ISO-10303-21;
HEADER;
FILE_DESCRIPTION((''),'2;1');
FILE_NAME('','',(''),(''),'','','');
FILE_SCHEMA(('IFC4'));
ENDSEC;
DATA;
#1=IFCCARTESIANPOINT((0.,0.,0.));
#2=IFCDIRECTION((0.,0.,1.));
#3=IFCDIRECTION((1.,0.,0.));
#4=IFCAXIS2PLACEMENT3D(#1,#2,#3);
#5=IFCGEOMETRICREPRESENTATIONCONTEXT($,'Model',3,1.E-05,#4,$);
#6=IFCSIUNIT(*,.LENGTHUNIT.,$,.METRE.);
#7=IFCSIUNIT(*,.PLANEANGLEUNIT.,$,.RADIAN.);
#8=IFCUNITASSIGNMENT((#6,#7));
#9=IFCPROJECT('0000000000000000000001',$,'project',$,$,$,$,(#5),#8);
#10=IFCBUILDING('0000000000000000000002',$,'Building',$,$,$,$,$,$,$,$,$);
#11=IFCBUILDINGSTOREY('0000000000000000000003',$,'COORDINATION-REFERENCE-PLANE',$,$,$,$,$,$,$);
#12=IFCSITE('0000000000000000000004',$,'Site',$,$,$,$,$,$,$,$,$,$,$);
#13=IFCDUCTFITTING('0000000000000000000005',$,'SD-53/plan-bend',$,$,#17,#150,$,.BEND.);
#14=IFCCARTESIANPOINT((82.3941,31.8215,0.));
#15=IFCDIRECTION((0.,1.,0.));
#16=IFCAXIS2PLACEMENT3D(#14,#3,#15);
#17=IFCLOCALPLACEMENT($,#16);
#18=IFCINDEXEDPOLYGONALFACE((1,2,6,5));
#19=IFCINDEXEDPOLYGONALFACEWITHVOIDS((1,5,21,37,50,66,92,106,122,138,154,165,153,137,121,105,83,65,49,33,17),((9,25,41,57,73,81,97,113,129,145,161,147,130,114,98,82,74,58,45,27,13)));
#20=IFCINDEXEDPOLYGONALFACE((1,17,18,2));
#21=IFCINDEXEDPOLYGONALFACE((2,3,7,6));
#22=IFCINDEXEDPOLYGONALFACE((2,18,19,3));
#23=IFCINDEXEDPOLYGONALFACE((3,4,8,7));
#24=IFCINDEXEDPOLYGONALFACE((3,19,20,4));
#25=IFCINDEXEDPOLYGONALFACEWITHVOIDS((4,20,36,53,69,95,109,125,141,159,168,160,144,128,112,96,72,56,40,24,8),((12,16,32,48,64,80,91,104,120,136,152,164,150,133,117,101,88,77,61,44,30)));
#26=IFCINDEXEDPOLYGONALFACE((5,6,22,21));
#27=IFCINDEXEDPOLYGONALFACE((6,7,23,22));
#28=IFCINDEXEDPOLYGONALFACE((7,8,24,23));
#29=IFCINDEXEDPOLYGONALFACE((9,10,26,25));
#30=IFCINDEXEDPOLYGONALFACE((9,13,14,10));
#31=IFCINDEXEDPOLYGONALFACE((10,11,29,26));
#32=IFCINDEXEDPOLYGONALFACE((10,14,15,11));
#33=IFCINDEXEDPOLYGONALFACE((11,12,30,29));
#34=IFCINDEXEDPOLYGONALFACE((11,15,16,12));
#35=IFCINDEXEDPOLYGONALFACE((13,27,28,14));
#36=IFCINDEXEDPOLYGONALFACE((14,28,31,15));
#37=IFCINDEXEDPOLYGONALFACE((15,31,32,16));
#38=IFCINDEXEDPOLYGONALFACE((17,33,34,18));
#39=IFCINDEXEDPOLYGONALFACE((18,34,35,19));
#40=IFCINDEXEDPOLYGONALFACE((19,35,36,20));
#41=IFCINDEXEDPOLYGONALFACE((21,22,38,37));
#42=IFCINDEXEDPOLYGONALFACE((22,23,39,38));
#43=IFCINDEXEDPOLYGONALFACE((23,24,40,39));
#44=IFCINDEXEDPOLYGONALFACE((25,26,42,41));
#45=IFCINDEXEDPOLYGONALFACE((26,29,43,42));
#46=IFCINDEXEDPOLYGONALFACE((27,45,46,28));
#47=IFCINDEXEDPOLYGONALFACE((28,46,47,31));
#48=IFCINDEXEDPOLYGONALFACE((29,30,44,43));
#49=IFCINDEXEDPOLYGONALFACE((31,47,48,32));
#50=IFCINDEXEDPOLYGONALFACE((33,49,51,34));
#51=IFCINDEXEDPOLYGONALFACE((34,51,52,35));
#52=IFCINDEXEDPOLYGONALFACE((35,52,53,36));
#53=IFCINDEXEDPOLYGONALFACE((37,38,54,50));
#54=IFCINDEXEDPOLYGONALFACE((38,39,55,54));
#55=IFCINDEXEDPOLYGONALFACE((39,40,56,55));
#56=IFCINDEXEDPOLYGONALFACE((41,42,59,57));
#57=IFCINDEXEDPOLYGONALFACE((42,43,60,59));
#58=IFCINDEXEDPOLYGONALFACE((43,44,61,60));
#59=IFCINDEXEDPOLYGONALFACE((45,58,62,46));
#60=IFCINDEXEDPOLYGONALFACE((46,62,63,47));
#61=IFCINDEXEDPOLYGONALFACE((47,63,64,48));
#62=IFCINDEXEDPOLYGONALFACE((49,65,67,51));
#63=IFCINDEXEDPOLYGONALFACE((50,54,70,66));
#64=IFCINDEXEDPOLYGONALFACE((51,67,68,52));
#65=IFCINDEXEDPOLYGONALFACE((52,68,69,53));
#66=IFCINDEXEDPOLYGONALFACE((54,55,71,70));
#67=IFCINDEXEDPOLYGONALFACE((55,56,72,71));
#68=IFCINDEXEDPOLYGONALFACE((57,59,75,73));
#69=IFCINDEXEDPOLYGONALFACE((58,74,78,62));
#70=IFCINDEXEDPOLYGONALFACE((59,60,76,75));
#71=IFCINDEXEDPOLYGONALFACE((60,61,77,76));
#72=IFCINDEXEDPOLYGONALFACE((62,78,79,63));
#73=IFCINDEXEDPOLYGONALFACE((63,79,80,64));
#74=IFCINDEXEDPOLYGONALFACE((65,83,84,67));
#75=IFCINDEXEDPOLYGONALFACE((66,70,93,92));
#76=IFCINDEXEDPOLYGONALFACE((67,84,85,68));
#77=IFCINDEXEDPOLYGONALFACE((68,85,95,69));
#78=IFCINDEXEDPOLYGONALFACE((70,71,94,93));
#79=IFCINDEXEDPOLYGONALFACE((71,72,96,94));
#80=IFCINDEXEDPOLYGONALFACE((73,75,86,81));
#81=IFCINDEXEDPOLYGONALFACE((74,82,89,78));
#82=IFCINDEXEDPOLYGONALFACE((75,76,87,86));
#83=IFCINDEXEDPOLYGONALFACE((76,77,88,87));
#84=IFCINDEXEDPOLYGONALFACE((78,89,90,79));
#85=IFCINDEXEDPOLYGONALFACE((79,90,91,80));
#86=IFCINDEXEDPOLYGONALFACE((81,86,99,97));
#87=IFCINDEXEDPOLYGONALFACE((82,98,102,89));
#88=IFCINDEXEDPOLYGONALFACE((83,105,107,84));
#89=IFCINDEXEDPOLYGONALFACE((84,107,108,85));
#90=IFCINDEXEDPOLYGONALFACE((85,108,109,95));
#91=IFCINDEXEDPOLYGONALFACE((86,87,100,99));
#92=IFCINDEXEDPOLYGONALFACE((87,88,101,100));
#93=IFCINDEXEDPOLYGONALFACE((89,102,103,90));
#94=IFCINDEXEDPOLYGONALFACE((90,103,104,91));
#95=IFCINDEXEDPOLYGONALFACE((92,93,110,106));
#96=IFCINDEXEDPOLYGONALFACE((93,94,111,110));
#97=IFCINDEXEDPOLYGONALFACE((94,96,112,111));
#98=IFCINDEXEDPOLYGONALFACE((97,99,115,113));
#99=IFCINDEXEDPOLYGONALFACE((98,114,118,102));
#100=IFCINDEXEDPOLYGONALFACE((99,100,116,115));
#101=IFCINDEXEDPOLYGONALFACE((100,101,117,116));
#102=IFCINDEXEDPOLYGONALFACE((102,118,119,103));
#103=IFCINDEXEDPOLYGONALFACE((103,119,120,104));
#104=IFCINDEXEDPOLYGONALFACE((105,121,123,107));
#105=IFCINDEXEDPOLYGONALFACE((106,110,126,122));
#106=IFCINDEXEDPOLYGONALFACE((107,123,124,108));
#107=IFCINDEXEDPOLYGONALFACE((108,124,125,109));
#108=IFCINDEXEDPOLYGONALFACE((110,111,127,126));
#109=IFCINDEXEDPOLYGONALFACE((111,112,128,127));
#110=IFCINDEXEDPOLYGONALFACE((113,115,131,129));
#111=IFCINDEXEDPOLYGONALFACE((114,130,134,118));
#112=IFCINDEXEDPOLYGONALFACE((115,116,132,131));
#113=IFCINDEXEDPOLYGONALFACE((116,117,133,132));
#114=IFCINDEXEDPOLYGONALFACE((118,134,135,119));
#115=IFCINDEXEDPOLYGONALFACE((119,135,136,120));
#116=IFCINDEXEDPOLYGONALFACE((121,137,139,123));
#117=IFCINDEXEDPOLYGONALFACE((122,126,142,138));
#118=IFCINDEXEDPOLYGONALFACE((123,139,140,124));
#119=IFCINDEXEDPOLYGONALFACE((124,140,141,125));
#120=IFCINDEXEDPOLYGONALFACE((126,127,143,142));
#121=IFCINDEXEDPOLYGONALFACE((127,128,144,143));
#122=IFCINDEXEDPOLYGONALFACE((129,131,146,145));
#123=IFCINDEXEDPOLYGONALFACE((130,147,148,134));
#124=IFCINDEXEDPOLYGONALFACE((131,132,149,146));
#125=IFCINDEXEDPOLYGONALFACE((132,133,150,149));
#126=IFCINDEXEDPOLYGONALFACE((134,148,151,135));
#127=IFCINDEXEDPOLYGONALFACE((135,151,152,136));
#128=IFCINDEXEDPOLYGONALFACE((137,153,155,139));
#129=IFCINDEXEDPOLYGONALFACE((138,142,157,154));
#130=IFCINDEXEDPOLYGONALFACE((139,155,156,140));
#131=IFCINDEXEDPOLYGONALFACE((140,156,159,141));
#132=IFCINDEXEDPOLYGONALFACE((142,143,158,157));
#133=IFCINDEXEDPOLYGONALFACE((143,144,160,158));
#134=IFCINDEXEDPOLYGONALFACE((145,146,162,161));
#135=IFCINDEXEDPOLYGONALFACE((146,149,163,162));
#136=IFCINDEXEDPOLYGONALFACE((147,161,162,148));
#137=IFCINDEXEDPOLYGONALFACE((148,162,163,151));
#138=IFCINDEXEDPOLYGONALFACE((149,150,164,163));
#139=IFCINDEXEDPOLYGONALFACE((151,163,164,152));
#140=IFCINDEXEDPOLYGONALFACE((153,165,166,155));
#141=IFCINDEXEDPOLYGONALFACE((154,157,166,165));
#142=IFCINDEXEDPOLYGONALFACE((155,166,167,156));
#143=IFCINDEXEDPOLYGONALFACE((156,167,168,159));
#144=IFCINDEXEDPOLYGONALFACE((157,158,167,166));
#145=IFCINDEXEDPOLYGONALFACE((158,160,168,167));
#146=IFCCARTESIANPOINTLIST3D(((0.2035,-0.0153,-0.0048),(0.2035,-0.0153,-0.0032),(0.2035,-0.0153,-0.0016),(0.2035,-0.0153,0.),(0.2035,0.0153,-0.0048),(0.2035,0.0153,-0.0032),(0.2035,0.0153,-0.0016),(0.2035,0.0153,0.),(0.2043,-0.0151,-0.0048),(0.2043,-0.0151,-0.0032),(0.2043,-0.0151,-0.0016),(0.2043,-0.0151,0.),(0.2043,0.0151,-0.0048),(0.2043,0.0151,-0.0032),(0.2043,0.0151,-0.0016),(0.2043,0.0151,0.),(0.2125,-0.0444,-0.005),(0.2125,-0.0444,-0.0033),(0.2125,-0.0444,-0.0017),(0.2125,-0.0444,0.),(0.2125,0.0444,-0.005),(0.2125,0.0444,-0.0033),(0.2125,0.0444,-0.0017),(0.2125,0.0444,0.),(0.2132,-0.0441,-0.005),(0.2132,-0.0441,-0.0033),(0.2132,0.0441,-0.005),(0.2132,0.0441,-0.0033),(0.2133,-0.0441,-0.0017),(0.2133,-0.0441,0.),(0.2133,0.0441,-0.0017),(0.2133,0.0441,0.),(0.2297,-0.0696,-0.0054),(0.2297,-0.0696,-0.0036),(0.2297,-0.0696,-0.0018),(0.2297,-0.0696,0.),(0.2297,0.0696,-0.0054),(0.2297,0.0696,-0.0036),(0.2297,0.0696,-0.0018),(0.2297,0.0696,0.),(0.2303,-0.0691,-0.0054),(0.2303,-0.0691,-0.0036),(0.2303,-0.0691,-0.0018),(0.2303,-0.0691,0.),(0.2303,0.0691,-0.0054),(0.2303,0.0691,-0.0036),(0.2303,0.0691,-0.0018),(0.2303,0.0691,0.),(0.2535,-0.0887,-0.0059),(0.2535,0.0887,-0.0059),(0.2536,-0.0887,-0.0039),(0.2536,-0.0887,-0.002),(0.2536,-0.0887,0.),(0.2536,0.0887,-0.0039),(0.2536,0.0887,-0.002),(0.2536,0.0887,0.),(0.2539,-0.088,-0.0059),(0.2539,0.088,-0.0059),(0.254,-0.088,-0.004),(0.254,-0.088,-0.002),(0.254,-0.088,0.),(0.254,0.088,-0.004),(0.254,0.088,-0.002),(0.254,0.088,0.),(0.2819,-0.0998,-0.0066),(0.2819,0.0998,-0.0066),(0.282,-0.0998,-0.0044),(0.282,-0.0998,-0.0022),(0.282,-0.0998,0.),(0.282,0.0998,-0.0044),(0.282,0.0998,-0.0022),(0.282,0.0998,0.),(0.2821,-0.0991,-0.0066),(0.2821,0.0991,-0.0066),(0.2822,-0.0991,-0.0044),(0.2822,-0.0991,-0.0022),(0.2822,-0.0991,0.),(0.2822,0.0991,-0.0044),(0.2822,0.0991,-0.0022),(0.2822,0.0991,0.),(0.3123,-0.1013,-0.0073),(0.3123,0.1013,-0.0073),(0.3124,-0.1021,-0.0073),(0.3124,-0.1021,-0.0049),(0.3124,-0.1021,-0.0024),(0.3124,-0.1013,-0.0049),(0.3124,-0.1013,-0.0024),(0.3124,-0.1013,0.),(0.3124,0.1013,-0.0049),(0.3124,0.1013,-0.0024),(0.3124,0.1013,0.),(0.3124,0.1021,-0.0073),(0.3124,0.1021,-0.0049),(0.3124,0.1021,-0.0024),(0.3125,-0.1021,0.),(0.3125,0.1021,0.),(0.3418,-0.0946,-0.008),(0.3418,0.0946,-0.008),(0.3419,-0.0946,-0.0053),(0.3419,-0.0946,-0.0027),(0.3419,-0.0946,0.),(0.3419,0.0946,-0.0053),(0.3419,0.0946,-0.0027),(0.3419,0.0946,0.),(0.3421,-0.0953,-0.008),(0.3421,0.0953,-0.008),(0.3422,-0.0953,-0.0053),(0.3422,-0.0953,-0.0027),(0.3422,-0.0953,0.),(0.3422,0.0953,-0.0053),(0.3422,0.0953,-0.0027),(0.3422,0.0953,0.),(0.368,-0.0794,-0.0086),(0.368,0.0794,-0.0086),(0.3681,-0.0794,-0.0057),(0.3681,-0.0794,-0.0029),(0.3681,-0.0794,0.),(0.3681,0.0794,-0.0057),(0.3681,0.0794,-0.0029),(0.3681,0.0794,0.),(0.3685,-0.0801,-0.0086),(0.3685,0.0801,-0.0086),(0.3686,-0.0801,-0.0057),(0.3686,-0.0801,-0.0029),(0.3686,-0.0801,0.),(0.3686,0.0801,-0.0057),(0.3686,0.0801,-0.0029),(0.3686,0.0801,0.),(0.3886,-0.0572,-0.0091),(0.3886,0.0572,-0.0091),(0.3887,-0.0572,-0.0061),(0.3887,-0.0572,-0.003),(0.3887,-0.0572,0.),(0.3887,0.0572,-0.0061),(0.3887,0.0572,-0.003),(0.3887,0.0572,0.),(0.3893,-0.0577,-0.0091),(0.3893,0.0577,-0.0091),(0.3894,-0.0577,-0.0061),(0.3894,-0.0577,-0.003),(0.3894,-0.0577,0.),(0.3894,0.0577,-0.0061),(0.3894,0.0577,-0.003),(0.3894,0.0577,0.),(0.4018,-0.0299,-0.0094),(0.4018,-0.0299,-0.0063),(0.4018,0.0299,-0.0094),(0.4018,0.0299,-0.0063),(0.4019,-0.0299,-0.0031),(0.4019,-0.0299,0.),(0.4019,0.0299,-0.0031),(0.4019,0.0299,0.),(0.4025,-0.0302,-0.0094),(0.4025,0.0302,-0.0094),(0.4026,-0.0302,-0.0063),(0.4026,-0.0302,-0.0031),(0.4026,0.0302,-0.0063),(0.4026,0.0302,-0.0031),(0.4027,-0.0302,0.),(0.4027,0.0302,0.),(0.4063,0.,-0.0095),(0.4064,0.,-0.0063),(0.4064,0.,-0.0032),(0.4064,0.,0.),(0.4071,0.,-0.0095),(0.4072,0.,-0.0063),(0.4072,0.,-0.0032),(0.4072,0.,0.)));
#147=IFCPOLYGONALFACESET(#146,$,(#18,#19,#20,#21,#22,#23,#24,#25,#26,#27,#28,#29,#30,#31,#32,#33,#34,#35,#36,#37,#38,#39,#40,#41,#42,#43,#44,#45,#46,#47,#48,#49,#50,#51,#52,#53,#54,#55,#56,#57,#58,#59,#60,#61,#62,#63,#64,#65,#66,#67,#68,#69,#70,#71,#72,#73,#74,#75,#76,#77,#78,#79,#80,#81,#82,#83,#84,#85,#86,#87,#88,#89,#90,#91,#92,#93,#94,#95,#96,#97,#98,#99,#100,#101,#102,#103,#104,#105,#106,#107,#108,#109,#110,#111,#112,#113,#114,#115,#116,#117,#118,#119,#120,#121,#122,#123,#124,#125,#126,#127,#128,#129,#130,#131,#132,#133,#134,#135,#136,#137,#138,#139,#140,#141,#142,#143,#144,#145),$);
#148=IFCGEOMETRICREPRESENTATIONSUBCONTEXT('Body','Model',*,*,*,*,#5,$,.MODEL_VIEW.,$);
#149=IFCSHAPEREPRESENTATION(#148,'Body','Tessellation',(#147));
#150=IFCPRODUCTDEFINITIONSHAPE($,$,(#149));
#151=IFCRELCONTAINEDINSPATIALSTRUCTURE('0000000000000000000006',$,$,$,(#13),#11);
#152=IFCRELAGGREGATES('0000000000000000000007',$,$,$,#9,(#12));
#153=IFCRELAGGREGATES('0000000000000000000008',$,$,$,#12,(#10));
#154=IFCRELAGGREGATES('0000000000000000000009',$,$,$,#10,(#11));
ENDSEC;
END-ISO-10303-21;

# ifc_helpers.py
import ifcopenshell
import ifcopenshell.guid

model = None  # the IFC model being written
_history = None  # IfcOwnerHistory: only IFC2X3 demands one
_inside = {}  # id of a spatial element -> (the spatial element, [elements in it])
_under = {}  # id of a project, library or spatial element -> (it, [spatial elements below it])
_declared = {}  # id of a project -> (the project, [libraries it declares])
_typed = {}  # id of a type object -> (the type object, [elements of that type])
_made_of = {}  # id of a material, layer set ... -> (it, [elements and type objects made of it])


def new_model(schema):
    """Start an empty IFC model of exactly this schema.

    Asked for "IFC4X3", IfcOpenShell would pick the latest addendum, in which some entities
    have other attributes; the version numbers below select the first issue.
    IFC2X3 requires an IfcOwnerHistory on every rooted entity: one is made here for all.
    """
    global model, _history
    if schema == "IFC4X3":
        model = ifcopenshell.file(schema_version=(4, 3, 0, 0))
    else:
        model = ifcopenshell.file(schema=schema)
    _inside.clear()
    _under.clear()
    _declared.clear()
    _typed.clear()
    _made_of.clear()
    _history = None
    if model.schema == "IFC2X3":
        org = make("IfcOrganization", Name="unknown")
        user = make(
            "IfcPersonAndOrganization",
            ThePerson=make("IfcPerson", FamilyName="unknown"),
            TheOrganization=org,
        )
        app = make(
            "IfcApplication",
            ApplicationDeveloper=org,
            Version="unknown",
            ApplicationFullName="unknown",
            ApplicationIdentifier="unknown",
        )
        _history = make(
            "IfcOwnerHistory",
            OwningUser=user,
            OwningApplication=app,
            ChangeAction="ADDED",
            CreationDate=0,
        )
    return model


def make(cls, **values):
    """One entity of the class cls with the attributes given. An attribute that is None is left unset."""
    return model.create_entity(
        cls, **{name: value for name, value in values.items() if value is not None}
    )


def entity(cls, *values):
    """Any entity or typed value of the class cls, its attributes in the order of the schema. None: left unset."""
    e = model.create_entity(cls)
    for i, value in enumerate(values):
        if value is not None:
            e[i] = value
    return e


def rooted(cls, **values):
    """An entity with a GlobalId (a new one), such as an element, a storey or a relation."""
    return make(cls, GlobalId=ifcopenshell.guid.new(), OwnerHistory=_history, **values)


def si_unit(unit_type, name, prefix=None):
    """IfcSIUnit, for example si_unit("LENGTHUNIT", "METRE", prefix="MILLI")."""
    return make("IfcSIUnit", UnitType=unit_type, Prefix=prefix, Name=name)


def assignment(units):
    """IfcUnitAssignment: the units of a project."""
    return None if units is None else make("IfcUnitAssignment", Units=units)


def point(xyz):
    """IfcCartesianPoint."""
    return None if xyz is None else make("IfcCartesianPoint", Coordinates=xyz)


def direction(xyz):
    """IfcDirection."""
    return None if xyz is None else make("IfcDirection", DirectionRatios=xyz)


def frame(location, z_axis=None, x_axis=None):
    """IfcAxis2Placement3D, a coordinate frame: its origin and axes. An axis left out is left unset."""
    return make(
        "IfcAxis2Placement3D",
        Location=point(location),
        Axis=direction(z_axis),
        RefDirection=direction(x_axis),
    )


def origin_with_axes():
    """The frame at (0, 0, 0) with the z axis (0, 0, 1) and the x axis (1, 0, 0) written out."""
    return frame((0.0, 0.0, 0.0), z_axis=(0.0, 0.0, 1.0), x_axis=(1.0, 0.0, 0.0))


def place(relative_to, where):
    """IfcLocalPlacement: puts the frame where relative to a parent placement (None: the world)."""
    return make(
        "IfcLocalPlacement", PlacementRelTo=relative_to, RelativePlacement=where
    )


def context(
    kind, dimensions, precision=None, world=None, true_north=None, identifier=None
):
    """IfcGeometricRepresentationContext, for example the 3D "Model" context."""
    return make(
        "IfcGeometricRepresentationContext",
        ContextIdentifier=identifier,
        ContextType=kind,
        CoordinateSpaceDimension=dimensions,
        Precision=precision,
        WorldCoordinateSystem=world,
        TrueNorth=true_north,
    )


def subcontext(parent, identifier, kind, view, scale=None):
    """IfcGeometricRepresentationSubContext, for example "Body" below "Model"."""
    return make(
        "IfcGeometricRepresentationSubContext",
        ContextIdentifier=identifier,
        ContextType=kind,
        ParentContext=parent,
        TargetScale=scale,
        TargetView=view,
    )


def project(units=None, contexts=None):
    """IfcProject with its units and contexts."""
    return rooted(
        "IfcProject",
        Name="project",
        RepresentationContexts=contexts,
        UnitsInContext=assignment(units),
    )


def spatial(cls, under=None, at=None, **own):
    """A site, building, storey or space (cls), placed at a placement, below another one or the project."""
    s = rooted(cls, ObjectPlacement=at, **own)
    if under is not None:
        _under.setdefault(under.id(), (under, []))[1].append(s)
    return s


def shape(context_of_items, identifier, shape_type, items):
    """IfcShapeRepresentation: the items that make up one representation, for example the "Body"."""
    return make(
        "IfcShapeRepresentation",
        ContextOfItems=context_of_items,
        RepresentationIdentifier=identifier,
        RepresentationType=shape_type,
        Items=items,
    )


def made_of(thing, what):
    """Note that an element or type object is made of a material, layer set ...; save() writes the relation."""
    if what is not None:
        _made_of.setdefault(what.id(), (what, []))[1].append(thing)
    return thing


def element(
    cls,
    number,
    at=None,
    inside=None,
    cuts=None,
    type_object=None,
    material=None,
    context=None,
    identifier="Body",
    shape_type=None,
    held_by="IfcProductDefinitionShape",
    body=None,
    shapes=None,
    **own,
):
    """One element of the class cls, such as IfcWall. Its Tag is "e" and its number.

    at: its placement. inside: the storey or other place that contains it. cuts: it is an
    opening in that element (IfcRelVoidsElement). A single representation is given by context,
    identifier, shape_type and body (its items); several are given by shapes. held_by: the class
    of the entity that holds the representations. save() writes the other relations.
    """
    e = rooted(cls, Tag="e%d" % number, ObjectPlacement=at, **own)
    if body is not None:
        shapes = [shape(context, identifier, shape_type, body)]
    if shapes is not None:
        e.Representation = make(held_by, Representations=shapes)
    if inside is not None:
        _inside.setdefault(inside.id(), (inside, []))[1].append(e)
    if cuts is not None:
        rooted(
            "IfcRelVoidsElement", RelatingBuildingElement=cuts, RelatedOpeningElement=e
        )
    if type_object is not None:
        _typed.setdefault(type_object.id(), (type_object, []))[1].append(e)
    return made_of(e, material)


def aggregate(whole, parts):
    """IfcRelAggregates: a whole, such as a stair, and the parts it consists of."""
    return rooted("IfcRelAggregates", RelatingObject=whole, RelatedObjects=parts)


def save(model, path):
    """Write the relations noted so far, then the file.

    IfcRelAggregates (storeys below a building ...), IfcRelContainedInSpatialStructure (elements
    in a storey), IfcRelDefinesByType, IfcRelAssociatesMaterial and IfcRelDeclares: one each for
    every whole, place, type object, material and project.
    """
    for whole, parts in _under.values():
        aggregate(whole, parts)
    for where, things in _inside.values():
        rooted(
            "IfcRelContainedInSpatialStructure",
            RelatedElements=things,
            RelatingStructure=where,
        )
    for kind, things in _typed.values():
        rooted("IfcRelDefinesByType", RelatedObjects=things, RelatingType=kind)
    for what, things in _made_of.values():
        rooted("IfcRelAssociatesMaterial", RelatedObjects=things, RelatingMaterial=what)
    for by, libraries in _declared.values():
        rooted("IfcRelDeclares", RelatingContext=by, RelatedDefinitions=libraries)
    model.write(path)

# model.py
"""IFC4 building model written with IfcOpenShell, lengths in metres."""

from ifc_helpers import new_model, entity, si_unit, frame, origin_with_axes, place, context, subcontext, project, spatial, element, save


model = new_model("IFC4")

# Units and contexts
model_context_1 = context("Model", 3, precision=1e-05, world=origin_with_axes())
body_context_1 = subcontext(model_context_1, "Body", "Model", "MODEL_VIEW")
ifc_project = project(units=[si_unit("LENGTHUNIT", "METRE"), si_unit("PLANEANGLEUNIT", "RADIAN")], contexts=[model_context_1])

# Site, building, storey
site = spatial("IfcSite", under=ifc_project, Name="Site")
building = spatial("IfcBuilding", under=site, Name="Building")
storey = spatial("IfcBuildingStorey", under=building, Name="COORDINATION-REFERENCE-PLANE")

# Duct fitting
duct_fitting_1_placement = place(None, frame((82.3941, 31.8215, 0.0), z_axis=(1.0, 0.0, 0.0), x_axis=(0.0, 1.0, 0.0)))
element("IfcDuctFitting", 1, at=duct_fitting_1_placement, inside=storey, Name="SD-53/plan-bend", PredefinedType="BEND", context=body_context_1, shape_type="SweptSolid", body=[
    entity("IfcRevolvedAreaSolid", entity("IfcCircleHollowProfileDef", "AREA", None, entity("IfcAxis2Placement2D", entity("IfcCartesianPoint", [0.3048, 0.0])), 0.1024, 0.0008), entity("IfcAxis2Placement3D", entity("IfcCartesianPoint", [0.0, 0.0, 0.0]), entity("IfcDirection", [0.0, 0.0, 1.0]), entity("IfcDirection", [1.0, 0.0, 0.0])), entity("IfcAxis1Placement", entity("IfcCartesianPoint", [0.0, 0.0, 0.0]), entity("IfcDirection", [0.0, 1.0, 0.0])), 0.023363),
])

save(model, "model.ifc")
